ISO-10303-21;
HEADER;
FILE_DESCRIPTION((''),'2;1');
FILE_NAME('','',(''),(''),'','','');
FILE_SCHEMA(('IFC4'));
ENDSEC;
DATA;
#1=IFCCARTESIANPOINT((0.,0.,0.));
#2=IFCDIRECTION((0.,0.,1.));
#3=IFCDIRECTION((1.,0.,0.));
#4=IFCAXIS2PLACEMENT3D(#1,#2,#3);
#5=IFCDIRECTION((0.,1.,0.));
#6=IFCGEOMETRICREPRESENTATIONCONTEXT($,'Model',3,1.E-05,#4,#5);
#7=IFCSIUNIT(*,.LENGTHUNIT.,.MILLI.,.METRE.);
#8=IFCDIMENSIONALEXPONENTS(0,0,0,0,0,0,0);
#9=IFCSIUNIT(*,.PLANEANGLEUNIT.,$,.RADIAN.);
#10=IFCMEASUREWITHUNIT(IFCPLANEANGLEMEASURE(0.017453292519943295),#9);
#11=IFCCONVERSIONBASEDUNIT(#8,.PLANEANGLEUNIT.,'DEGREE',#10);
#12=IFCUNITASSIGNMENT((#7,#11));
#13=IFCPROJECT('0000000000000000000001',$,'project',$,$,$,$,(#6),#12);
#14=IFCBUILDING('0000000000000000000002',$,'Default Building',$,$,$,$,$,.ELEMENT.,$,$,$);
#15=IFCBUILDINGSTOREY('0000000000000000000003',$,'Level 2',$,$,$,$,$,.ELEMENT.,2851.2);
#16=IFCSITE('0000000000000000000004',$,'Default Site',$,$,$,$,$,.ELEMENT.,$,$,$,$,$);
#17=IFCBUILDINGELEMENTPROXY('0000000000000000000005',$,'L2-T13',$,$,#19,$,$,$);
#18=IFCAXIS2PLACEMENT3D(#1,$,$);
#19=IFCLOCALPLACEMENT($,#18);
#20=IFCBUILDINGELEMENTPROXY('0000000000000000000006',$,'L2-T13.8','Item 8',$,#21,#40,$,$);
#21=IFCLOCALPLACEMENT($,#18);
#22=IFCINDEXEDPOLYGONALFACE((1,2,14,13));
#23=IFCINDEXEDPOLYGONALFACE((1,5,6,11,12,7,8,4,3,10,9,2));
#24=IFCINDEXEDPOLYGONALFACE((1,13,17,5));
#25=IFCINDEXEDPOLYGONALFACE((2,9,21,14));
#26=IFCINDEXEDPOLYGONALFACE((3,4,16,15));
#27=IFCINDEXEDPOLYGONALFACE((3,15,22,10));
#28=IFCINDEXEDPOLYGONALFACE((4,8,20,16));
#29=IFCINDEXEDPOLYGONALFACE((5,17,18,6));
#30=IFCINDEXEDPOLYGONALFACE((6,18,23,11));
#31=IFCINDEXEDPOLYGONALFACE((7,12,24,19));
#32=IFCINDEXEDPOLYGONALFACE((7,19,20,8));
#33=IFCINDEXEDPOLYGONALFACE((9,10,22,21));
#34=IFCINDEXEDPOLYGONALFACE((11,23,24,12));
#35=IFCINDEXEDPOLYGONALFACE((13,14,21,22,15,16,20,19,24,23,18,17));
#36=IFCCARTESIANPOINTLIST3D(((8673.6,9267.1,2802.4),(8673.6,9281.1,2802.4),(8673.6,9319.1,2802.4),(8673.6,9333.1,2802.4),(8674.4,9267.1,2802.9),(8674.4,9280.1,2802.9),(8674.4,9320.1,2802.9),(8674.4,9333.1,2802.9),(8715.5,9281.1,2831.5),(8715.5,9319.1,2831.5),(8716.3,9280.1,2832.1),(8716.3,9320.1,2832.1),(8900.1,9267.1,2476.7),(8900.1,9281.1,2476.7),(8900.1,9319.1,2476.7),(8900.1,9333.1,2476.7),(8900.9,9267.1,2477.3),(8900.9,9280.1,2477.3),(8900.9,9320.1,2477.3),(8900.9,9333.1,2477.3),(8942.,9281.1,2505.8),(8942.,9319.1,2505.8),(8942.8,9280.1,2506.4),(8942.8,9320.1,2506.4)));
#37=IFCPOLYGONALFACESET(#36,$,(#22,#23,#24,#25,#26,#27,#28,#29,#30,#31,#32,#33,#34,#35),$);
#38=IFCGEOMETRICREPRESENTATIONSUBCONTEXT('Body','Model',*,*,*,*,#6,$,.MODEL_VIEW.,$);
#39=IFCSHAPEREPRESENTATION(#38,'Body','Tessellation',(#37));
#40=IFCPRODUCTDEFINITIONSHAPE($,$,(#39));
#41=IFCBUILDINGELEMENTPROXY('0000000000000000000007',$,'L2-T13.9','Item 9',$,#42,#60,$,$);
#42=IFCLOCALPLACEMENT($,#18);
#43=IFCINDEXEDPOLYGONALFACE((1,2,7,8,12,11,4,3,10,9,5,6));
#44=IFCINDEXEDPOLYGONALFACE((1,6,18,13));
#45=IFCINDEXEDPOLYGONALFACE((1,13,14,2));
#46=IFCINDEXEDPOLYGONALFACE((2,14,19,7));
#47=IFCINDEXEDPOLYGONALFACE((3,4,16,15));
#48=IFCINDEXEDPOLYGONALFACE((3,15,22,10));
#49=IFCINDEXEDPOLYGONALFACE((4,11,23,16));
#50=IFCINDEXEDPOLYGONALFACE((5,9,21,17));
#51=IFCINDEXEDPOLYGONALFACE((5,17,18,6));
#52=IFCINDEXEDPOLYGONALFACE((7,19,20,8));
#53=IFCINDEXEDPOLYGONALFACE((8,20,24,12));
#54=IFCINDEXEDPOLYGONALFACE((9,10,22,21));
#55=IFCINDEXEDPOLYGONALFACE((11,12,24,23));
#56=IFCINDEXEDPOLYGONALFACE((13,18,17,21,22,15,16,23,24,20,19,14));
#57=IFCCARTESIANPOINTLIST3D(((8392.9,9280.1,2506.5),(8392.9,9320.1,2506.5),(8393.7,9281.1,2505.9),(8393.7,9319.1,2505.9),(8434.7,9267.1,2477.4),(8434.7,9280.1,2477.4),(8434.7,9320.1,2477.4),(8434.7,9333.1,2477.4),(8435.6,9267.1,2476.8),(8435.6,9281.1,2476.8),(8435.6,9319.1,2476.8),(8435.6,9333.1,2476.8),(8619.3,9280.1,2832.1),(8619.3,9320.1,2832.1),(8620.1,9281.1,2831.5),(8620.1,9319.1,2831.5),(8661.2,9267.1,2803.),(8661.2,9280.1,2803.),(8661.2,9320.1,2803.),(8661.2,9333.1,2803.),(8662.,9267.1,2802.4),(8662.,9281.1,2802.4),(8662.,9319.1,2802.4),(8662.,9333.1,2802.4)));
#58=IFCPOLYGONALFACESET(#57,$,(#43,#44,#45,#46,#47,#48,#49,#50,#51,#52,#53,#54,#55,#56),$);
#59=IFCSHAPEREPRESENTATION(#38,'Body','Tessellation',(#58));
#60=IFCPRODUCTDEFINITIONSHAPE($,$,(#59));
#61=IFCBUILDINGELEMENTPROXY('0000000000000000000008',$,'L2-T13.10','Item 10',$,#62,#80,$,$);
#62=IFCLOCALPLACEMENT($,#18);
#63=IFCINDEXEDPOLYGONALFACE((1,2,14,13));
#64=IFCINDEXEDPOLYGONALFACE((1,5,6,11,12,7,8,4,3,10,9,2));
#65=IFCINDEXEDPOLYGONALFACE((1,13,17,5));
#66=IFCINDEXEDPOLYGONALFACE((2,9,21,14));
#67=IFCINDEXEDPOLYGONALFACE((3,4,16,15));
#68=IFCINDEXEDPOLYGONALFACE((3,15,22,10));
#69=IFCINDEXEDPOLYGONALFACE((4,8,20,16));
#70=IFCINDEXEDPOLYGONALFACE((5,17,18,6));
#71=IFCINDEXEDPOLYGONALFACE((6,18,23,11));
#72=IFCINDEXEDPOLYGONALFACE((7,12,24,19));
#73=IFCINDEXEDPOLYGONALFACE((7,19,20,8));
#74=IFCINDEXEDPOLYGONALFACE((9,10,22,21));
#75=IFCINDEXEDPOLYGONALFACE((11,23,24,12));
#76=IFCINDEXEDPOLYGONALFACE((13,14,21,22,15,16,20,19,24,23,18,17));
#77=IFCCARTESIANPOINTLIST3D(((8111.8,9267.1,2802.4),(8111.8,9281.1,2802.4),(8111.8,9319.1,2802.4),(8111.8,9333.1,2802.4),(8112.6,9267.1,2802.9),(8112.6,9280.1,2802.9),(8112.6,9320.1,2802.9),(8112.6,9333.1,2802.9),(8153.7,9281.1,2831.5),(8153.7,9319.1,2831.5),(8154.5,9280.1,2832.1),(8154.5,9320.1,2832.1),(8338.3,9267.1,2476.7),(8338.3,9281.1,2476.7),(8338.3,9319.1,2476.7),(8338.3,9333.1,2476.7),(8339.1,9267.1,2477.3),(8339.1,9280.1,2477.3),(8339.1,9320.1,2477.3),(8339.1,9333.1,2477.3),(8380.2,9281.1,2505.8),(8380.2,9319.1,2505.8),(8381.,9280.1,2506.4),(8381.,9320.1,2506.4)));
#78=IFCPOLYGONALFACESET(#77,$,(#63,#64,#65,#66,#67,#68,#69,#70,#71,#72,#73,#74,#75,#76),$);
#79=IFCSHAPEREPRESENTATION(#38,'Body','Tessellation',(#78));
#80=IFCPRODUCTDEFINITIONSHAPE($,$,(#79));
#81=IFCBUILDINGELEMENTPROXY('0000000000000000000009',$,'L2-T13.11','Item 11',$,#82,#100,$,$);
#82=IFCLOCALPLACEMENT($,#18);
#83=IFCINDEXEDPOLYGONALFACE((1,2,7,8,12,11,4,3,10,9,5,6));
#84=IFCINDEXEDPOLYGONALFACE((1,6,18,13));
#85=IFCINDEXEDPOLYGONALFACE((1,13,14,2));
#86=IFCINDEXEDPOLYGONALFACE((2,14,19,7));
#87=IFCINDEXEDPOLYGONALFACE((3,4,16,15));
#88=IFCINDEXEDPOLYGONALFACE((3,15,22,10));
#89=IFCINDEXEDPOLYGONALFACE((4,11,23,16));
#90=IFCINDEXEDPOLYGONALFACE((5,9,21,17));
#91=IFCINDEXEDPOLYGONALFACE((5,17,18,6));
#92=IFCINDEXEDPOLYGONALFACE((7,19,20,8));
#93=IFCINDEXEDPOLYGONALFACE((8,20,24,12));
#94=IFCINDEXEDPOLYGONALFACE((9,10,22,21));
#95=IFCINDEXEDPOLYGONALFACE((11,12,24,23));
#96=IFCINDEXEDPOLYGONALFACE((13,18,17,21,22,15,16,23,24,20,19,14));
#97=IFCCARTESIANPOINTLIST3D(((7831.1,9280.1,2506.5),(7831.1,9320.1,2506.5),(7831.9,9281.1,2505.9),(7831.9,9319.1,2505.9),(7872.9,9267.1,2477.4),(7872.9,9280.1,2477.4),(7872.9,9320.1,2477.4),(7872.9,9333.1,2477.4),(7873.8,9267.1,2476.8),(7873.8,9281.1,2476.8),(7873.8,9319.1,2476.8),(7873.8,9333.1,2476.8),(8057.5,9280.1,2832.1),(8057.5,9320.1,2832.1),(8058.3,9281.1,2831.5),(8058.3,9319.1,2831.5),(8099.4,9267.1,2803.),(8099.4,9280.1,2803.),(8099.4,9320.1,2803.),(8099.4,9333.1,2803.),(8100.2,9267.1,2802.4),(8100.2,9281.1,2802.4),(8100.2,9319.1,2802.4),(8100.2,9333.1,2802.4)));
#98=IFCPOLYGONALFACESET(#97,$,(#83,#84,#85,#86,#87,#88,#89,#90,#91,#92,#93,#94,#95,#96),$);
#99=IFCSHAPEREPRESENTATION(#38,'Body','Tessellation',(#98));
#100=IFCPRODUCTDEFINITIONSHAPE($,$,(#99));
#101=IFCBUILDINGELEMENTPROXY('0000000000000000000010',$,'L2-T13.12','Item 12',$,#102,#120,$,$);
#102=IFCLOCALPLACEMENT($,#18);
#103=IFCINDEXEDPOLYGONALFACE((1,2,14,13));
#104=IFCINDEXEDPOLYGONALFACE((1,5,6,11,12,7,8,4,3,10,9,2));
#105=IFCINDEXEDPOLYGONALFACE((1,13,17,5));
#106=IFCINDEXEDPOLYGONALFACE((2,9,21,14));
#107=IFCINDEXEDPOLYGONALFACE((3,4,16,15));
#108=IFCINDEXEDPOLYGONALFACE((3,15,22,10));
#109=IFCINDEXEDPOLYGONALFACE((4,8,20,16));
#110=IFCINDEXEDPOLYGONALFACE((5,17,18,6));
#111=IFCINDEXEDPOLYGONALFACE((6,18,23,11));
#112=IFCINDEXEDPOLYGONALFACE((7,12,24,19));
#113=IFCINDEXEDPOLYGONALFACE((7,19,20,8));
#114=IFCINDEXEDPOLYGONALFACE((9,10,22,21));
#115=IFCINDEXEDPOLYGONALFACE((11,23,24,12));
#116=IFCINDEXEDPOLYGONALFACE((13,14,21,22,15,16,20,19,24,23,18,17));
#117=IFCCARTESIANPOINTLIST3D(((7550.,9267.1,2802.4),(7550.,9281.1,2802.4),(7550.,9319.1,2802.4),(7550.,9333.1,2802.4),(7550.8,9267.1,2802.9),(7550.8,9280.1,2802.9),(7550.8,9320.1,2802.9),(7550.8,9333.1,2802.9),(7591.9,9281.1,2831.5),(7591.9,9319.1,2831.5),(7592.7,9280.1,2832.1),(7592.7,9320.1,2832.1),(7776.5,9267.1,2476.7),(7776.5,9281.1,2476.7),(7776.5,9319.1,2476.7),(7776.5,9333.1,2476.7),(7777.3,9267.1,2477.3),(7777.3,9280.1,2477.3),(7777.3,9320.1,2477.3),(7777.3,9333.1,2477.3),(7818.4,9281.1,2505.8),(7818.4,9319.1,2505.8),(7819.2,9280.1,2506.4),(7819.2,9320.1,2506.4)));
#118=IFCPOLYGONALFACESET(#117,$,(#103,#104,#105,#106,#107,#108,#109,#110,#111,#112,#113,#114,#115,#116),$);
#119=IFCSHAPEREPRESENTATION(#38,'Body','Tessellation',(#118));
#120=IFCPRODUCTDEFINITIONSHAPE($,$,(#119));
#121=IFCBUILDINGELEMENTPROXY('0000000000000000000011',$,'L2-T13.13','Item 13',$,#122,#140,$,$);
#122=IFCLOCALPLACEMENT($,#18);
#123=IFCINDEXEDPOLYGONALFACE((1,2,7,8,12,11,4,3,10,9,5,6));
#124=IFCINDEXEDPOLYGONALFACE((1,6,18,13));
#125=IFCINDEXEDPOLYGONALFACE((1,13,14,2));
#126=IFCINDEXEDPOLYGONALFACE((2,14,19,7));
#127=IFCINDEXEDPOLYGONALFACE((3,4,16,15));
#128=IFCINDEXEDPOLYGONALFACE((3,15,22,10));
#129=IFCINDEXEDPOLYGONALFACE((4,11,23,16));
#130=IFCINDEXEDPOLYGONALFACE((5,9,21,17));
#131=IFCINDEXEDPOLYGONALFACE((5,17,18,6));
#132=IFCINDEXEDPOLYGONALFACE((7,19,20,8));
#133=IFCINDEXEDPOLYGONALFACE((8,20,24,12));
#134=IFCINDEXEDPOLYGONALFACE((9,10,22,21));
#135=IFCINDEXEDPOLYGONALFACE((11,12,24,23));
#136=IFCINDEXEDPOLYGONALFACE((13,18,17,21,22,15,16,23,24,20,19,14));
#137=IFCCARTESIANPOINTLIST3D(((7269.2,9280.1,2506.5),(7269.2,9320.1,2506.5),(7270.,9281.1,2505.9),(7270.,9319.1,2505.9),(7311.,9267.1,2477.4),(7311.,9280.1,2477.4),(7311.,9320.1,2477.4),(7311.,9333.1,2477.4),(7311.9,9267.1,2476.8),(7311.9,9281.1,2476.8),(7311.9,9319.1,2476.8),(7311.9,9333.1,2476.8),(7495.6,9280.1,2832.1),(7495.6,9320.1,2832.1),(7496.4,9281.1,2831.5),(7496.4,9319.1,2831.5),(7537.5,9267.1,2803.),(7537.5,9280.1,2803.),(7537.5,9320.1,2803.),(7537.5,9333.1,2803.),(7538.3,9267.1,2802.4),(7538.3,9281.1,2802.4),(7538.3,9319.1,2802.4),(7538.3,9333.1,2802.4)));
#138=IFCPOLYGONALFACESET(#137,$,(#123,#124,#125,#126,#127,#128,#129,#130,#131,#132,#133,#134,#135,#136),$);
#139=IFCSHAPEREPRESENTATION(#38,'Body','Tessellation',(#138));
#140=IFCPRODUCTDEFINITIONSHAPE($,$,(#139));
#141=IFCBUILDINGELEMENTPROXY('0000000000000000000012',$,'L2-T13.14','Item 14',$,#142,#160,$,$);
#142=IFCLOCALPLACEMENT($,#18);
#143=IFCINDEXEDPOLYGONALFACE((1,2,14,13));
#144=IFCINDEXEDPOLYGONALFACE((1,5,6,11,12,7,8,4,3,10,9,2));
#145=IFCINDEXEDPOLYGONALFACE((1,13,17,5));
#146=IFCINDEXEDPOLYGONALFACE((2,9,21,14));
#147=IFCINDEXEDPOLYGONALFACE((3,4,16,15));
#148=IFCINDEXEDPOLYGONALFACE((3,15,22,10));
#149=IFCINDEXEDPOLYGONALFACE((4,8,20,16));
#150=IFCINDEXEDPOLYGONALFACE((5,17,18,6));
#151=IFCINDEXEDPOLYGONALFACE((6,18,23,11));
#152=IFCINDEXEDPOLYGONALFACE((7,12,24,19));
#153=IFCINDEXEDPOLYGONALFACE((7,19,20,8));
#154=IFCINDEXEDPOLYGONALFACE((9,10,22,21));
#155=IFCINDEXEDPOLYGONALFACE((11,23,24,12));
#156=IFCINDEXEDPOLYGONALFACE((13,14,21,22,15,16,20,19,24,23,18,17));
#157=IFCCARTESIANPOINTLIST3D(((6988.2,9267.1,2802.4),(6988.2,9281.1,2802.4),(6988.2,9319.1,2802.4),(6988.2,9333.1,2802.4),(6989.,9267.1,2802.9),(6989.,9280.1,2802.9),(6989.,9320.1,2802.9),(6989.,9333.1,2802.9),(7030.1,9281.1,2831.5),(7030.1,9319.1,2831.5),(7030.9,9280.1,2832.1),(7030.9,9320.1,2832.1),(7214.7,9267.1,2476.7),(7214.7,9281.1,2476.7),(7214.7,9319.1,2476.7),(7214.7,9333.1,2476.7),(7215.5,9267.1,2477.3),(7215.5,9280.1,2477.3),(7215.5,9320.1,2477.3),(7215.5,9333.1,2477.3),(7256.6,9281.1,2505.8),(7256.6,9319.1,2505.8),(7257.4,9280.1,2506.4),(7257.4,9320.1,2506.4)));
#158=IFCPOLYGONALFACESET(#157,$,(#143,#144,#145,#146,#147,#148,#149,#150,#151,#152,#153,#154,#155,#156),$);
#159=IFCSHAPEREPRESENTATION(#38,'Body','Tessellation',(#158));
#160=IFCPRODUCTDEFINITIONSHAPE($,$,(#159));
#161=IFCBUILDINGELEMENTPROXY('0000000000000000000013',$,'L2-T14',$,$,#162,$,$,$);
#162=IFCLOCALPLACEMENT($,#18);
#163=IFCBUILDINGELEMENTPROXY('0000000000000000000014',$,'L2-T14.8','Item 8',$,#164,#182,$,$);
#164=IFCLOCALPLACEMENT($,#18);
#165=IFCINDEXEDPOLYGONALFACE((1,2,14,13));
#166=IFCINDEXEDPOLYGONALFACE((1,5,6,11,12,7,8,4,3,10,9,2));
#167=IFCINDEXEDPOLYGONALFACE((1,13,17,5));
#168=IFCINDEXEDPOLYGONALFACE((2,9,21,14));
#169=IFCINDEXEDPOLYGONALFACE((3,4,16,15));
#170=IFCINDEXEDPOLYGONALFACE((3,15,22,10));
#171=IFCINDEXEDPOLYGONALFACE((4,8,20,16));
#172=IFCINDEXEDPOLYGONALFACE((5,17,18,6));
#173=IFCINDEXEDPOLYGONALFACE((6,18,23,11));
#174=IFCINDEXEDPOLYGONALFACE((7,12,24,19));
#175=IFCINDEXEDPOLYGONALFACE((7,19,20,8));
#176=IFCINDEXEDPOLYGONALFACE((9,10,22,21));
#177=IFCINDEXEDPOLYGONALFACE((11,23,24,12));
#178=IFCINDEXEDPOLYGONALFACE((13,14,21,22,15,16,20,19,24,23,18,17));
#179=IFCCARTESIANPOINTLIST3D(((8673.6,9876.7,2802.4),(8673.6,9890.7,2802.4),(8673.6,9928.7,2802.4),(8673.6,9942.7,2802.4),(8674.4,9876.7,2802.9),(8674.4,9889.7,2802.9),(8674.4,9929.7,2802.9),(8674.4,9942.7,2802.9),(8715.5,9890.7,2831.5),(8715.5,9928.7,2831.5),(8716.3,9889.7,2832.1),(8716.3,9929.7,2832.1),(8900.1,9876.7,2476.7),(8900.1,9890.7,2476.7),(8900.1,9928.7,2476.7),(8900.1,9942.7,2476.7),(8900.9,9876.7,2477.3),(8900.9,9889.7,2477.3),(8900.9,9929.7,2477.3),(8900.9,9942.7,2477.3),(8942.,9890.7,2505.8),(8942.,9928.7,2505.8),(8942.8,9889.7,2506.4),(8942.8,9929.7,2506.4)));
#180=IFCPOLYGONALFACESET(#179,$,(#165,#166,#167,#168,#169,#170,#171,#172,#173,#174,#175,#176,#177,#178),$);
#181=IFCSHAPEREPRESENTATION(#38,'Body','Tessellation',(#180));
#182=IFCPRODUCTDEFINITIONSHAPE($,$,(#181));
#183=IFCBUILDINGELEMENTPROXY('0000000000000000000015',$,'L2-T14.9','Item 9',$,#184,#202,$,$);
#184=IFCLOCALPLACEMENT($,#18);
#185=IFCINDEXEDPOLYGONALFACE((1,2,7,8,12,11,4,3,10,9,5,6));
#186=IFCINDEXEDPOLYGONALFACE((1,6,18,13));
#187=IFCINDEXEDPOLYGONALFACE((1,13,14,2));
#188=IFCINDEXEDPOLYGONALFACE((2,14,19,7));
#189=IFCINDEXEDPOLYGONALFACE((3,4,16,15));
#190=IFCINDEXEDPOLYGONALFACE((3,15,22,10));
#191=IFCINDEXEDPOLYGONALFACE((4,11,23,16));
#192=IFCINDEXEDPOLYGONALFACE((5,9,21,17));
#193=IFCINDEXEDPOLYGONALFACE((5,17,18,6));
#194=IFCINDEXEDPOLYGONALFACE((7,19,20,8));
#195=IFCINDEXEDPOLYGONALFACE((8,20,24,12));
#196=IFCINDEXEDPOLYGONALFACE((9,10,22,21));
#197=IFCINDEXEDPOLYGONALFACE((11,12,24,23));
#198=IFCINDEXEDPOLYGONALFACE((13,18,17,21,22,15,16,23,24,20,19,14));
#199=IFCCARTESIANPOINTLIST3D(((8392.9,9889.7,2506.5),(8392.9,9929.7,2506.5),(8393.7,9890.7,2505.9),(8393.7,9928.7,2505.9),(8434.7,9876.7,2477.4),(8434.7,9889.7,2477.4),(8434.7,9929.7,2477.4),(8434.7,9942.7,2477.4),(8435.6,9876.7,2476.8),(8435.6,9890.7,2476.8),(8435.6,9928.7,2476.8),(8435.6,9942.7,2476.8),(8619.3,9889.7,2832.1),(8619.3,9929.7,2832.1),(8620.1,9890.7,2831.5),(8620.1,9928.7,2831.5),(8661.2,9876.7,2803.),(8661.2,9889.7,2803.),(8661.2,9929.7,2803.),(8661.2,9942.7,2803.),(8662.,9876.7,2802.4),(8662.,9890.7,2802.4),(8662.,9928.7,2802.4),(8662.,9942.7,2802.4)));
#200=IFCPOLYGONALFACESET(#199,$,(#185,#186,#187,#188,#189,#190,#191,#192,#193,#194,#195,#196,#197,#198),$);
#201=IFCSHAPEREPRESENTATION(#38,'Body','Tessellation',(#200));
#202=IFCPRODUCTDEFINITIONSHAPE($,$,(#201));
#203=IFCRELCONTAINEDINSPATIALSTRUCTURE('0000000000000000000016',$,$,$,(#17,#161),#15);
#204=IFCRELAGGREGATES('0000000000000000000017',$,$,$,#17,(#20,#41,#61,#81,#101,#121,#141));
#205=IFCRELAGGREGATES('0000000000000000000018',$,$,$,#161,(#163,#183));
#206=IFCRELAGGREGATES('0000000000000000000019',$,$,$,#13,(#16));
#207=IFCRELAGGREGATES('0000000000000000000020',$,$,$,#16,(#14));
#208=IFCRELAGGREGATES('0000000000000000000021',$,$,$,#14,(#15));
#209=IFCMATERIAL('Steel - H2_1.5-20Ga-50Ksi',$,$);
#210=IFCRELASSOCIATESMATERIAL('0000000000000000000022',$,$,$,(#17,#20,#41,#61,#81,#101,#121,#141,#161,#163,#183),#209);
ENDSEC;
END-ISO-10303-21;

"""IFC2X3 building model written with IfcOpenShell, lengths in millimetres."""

from ifc_helpers import new_model, entity, si_unit, converted_unit, direction, frame, origin, origin_with_axes, place, context, subcontext, project, spatial, polyline, outline, extrude, material, element, aggregate, save


model = new_model("IFC2X3")

# Units and contexts
model_context = context("Model", 3, precision=1e-05, world=origin_with_axes(), true_north=direction((0.0, 1.0, 0.0)))
body_context = subcontext(model_context, "Body", "Model", "MODEL_VIEW")
ifc_project = project(units=[si_unit("LENGTHUNIT", "METRE", prefix="MILLI"), converted_unit("PLANEANGLEUNIT", "DEGREE", entity("IfcPlaneAngleMeasure", 0.017453292519943295), si_unit("PLANEANGLEUNIT", "RADIAN"), dimensions=[0, 0, 0, 0, 0, 0, 0])], contexts=[model_context])

# Site, building, storey
site = spatial("IfcSite", under=ifc_project, Name="Default Site", CompositionType="ELEMENT")
building = spatial("IfcBuilding", under=site, Name="Default Building", CompositionType="ELEMENT")
storey = spatial("IfcBuildingStorey", under=building, Name="Level 2", CompositionType="ELEMENT", Elevation=2851.2)

# Building element proxies
ifc_material_1 = material(Name="Steel - H2_1.5-20Ga-50Ksi")
proxy_1 = element("IfcBuildingElementProxy", 1, inside=storey, material=ifc_material_1, Name="L2-T13")
proxy_2_placement = place(None, frame((8900.1, 9333.1, 2476.7), z_axis=(-0.571, 0.0, 0.821), x_axis=(0.0, -40.0, 0.0)))
proxy_2 = element("IfcBuildingElementProxy", 2, at=proxy_2_placement, material=ifc_material_1, Name="L2-T13.8", Description="Item 8", context=body_context, shape_type="SweptSolid", body=[
    extrude(outline(polyline([(0.0, 0.0), (14.0, 0.0), (14.0, 51.0), (52.0, 51.0), (52.0, 0.0), (66.0, 0.0), (66.0, 1.0), (53.0, 1.0), (53.0, 52.0), (13.0, 52.0), (13.0, 1.0), (0.0, 1.0), (0.0, 0.0)])), origin(), (0.0, 0.0, 1.0), 396.7),
])
proxy_3_placement = place(None, frame((8662.0, 9333.1, 2802.4), z_axis=(-0.571, 0.0, -0.821), x_axis=(0.0, -40.0, 0.0)))
proxy_3 = element("IfcBuildingElementProxy", 3, at=proxy_3_placement, material=ifc_material_1, Name="L2-T13.9", Description="Item 9", context=body_context, shape_type="SweptSolid", body=[
    extrude(outline(polyline([(0.0, 0.0), (14.0, 0.0), (14.0, 51.0), (52.0, 51.0), (52.0, 0.0), (66.0, 0.0), (66.0, 1.0), (53.0, 1.0), (53.0, 52.0), (13.0, 52.0), (13.0, 1.0), (0.0, 1.0), (0.0, 0.0)])), origin(), (0.0, 0.0, 1.0), 396.6),
])
proxy_4_placement = place(None, frame((8338.3, 9333.1, 2476.7), z_axis=(-0.571, 0.0, 0.821), x_axis=(0.0, -40.0, 0.0)))
proxy_4 = element("IfcBuildingElementProxy", 4, at=proxy_4_placement, material=ifc_material_1, Name="L2-T13.10", Description="Item 10", context=body_context, shape_type="SweptSolid", body=[
    extrude(outline(polyline([(0.0, 0.0), (14.0, 0.0), (14.0, 51.0), (52.0, 51.0), (52.0, 0.0), (66.0, 0.0), (66.0, 1.0), (53.0, 1.0), (53.0, 52.0), (13.0, 52.0), (13.0, 1.0), (0.0, 1.0), (0.0, 0.0)])), origin(), (0.0, 0.0, 1.0), 396.7),
])
proxy_5_placement = place(None, frame((8100.2, 9333.1, 2802.4), z_axis=(-0.571, 0.0, -0.821), x_axis=(0.0, -40.0, 0.0)))
proxy_5 = element("IfcBuildingElementProxy", 5, at=proxy_5_placement, material=ifc_material_1, Name="L2-T13.11", Description="Item 11", context=body_context, shape_type="SweptSolid", body=[
    extrude(outline(polyline([(0.0, 0.0), (14.0, 0.0), (14.0, 51.0), (52.0, 51.0), (52.0, 0.0), (66.0, 0.0), (66.0, 1.0), (53.0, 1.0), (53.0, 52.0), (13.0, 52.0), (13.0, 1.0), (0.0, 1.0), (0.0, 0.0)])), origin(), (0.0, 0.0, 1.0), 396.6),
])
proxy_6_placement = place(None, frame((7776.5, 9333.1, 2476.7), z_axis=(-0.571, 0.0, 0.821), x_axis=(0.0, -40.0, 0.0)))
proxy_6 = element("IfcBuildingElementProxy", 6, at=proxy_6_placement, material=ifc_material_1, Name="L2-T13.12", Description="Item 12", context=body_context, shape_type="SweptSolid", body=[
    extrude(outline(polyline([(0.0, 0.0), (14.0, 0.0), (14.0, 51.0), (52.0, 51.0), (52.0, 0.0), (66.0, 0.0), (66.0, 1.0), (53.0, 1.0), (53.0, 52.0), (13.0, 52.0), (13.0, 1.0), (0.0, 1.0), (0.0, 0.0)])), origin(), (0.0, 0.0, 1.0), 396.7),
])
proxy_7_placement = place(None, frame((7538.3, 9333.1, 2802.4), z_axis=(-0.571, 0.0, -0.821), x_axis=(0.0, -40.0, 0.0)))
proxy_7 = element("IfcBuildingElementProxy", 7, at=proxy_7_placement, material=ifc_material_1, Name="L2-T13.13", Description="Item 13", context=body_context, shape_type="SweptSolid", body=[
    extrude(outline(polyline([(0.0, 0.0), (14.0, 0.0), (14.0, 51.0), (52.0, 51.0), (52.0, 0.0), (66.0, 0.0), (66.0, 1.0), (53.0, 1.0), (53.0, 52.0), (13.0, 52.0), (13.0, 1.0), (0.0, 1.0), (0.0, 0.0)])), origin(), (0.0, 0.0, 1.0), 396.6),
])
proxy_8_placement = place(None, frame((7214.7, 9333.1, 2476.7), z_axis=(-0.571, 0.0, 0.821), x_axis=(0.0, -40.0, 0.0)))
proxy_8 = element("IfcBuildingElementProxy", 8, at=proxy_8_placement, material=ifc_material_1, Name="L2-T13.14", Description="Item 14", context=body_context, shape_type="SweptSolid", body=[
    extrude(outline(polyline([(0.0, 0.0), (14.0, 0.0), (14.0, 51.0), (52.0, 51.0), (52.0, 0.0), (66.0, 0.0), (66.0, 1.0), (53.0, 1.0), (53.0, 52.0), (13.0, 52.0), (13.0, 1.0), (0.0, 1.0), (0.0, 0.0)])), origin(), (0.0, 0.0, 1.0), 396.7),
])
aggregate(proxy_1, [proxy_2, proxy_3, proxy_4, proxy_5, proxy_6, proxy_7, proxy_8])
proxy_9 = element("IfcBuildingElementProxy", 9, inside=storey, material=ifc_material_1, Name="L2-T14")
proxy_10_placement = place(None, frame((8900.1, 9942.7, 2476.7), z_axis=(-0.571, 0.0, 0.821), x_axis=(0.0, -40.0, 0.0)))
proxy_10 = element("IfcBuildingElementProxy", 10, at=proxy_10_placement, material=ifc_material_1, Name="L2-T14.8", Description="Item 8", context=body_context, shape_type="SweptSolid", body=[
    extrude(outline(polyline([(0.0, 0.0), (14.0, 0.0), (14.0, 51.0), (52.0, 51.0), (52.0, 0.0), (66.0, 0.0), (66.0, 1.0), (53.0, 1.0), (53.0, 52.0), (13.0, 52.0), (13.0, 1.0), (0.0, 1.0), (0.0, 0.0)])), origin(), (0.0, 0.0, 1.0), 396.7),
])
proxy_11_placement = place(None, frame((8662.0, 9942.7, 2802.4), z_axis=(-0.571, 0.0, -0.821), x_axis=(0.0, -40.0, 0.0)))
proxy_11 = element("IfcBuildingElementProxy", 11, at=proxy_11_placement, material=ifc_material_1, Name="L2-T14.9", Description="Item 9", context=body_context, shape_type="SweptSolid", body=[
    extrude(outline(polyline([(0.0, 0.0), (14.0, 0.0), (14.0, 51.0), (52.0, 51.0), (52.0, 0.0), (66.0, 0.0), (66.0, 1.0), (53.0, 1.0), (53.0, 52.0), (13.0, 52.0), (13.0, 1.0), (0.0, 1.0), (0.0, 0.0)])), origin(), (0.0, 0.0, 1.0), 396.6),
])
aggregate(proxy_9, [proxy_10, proxy_11])

save(model, "model.ifc")
